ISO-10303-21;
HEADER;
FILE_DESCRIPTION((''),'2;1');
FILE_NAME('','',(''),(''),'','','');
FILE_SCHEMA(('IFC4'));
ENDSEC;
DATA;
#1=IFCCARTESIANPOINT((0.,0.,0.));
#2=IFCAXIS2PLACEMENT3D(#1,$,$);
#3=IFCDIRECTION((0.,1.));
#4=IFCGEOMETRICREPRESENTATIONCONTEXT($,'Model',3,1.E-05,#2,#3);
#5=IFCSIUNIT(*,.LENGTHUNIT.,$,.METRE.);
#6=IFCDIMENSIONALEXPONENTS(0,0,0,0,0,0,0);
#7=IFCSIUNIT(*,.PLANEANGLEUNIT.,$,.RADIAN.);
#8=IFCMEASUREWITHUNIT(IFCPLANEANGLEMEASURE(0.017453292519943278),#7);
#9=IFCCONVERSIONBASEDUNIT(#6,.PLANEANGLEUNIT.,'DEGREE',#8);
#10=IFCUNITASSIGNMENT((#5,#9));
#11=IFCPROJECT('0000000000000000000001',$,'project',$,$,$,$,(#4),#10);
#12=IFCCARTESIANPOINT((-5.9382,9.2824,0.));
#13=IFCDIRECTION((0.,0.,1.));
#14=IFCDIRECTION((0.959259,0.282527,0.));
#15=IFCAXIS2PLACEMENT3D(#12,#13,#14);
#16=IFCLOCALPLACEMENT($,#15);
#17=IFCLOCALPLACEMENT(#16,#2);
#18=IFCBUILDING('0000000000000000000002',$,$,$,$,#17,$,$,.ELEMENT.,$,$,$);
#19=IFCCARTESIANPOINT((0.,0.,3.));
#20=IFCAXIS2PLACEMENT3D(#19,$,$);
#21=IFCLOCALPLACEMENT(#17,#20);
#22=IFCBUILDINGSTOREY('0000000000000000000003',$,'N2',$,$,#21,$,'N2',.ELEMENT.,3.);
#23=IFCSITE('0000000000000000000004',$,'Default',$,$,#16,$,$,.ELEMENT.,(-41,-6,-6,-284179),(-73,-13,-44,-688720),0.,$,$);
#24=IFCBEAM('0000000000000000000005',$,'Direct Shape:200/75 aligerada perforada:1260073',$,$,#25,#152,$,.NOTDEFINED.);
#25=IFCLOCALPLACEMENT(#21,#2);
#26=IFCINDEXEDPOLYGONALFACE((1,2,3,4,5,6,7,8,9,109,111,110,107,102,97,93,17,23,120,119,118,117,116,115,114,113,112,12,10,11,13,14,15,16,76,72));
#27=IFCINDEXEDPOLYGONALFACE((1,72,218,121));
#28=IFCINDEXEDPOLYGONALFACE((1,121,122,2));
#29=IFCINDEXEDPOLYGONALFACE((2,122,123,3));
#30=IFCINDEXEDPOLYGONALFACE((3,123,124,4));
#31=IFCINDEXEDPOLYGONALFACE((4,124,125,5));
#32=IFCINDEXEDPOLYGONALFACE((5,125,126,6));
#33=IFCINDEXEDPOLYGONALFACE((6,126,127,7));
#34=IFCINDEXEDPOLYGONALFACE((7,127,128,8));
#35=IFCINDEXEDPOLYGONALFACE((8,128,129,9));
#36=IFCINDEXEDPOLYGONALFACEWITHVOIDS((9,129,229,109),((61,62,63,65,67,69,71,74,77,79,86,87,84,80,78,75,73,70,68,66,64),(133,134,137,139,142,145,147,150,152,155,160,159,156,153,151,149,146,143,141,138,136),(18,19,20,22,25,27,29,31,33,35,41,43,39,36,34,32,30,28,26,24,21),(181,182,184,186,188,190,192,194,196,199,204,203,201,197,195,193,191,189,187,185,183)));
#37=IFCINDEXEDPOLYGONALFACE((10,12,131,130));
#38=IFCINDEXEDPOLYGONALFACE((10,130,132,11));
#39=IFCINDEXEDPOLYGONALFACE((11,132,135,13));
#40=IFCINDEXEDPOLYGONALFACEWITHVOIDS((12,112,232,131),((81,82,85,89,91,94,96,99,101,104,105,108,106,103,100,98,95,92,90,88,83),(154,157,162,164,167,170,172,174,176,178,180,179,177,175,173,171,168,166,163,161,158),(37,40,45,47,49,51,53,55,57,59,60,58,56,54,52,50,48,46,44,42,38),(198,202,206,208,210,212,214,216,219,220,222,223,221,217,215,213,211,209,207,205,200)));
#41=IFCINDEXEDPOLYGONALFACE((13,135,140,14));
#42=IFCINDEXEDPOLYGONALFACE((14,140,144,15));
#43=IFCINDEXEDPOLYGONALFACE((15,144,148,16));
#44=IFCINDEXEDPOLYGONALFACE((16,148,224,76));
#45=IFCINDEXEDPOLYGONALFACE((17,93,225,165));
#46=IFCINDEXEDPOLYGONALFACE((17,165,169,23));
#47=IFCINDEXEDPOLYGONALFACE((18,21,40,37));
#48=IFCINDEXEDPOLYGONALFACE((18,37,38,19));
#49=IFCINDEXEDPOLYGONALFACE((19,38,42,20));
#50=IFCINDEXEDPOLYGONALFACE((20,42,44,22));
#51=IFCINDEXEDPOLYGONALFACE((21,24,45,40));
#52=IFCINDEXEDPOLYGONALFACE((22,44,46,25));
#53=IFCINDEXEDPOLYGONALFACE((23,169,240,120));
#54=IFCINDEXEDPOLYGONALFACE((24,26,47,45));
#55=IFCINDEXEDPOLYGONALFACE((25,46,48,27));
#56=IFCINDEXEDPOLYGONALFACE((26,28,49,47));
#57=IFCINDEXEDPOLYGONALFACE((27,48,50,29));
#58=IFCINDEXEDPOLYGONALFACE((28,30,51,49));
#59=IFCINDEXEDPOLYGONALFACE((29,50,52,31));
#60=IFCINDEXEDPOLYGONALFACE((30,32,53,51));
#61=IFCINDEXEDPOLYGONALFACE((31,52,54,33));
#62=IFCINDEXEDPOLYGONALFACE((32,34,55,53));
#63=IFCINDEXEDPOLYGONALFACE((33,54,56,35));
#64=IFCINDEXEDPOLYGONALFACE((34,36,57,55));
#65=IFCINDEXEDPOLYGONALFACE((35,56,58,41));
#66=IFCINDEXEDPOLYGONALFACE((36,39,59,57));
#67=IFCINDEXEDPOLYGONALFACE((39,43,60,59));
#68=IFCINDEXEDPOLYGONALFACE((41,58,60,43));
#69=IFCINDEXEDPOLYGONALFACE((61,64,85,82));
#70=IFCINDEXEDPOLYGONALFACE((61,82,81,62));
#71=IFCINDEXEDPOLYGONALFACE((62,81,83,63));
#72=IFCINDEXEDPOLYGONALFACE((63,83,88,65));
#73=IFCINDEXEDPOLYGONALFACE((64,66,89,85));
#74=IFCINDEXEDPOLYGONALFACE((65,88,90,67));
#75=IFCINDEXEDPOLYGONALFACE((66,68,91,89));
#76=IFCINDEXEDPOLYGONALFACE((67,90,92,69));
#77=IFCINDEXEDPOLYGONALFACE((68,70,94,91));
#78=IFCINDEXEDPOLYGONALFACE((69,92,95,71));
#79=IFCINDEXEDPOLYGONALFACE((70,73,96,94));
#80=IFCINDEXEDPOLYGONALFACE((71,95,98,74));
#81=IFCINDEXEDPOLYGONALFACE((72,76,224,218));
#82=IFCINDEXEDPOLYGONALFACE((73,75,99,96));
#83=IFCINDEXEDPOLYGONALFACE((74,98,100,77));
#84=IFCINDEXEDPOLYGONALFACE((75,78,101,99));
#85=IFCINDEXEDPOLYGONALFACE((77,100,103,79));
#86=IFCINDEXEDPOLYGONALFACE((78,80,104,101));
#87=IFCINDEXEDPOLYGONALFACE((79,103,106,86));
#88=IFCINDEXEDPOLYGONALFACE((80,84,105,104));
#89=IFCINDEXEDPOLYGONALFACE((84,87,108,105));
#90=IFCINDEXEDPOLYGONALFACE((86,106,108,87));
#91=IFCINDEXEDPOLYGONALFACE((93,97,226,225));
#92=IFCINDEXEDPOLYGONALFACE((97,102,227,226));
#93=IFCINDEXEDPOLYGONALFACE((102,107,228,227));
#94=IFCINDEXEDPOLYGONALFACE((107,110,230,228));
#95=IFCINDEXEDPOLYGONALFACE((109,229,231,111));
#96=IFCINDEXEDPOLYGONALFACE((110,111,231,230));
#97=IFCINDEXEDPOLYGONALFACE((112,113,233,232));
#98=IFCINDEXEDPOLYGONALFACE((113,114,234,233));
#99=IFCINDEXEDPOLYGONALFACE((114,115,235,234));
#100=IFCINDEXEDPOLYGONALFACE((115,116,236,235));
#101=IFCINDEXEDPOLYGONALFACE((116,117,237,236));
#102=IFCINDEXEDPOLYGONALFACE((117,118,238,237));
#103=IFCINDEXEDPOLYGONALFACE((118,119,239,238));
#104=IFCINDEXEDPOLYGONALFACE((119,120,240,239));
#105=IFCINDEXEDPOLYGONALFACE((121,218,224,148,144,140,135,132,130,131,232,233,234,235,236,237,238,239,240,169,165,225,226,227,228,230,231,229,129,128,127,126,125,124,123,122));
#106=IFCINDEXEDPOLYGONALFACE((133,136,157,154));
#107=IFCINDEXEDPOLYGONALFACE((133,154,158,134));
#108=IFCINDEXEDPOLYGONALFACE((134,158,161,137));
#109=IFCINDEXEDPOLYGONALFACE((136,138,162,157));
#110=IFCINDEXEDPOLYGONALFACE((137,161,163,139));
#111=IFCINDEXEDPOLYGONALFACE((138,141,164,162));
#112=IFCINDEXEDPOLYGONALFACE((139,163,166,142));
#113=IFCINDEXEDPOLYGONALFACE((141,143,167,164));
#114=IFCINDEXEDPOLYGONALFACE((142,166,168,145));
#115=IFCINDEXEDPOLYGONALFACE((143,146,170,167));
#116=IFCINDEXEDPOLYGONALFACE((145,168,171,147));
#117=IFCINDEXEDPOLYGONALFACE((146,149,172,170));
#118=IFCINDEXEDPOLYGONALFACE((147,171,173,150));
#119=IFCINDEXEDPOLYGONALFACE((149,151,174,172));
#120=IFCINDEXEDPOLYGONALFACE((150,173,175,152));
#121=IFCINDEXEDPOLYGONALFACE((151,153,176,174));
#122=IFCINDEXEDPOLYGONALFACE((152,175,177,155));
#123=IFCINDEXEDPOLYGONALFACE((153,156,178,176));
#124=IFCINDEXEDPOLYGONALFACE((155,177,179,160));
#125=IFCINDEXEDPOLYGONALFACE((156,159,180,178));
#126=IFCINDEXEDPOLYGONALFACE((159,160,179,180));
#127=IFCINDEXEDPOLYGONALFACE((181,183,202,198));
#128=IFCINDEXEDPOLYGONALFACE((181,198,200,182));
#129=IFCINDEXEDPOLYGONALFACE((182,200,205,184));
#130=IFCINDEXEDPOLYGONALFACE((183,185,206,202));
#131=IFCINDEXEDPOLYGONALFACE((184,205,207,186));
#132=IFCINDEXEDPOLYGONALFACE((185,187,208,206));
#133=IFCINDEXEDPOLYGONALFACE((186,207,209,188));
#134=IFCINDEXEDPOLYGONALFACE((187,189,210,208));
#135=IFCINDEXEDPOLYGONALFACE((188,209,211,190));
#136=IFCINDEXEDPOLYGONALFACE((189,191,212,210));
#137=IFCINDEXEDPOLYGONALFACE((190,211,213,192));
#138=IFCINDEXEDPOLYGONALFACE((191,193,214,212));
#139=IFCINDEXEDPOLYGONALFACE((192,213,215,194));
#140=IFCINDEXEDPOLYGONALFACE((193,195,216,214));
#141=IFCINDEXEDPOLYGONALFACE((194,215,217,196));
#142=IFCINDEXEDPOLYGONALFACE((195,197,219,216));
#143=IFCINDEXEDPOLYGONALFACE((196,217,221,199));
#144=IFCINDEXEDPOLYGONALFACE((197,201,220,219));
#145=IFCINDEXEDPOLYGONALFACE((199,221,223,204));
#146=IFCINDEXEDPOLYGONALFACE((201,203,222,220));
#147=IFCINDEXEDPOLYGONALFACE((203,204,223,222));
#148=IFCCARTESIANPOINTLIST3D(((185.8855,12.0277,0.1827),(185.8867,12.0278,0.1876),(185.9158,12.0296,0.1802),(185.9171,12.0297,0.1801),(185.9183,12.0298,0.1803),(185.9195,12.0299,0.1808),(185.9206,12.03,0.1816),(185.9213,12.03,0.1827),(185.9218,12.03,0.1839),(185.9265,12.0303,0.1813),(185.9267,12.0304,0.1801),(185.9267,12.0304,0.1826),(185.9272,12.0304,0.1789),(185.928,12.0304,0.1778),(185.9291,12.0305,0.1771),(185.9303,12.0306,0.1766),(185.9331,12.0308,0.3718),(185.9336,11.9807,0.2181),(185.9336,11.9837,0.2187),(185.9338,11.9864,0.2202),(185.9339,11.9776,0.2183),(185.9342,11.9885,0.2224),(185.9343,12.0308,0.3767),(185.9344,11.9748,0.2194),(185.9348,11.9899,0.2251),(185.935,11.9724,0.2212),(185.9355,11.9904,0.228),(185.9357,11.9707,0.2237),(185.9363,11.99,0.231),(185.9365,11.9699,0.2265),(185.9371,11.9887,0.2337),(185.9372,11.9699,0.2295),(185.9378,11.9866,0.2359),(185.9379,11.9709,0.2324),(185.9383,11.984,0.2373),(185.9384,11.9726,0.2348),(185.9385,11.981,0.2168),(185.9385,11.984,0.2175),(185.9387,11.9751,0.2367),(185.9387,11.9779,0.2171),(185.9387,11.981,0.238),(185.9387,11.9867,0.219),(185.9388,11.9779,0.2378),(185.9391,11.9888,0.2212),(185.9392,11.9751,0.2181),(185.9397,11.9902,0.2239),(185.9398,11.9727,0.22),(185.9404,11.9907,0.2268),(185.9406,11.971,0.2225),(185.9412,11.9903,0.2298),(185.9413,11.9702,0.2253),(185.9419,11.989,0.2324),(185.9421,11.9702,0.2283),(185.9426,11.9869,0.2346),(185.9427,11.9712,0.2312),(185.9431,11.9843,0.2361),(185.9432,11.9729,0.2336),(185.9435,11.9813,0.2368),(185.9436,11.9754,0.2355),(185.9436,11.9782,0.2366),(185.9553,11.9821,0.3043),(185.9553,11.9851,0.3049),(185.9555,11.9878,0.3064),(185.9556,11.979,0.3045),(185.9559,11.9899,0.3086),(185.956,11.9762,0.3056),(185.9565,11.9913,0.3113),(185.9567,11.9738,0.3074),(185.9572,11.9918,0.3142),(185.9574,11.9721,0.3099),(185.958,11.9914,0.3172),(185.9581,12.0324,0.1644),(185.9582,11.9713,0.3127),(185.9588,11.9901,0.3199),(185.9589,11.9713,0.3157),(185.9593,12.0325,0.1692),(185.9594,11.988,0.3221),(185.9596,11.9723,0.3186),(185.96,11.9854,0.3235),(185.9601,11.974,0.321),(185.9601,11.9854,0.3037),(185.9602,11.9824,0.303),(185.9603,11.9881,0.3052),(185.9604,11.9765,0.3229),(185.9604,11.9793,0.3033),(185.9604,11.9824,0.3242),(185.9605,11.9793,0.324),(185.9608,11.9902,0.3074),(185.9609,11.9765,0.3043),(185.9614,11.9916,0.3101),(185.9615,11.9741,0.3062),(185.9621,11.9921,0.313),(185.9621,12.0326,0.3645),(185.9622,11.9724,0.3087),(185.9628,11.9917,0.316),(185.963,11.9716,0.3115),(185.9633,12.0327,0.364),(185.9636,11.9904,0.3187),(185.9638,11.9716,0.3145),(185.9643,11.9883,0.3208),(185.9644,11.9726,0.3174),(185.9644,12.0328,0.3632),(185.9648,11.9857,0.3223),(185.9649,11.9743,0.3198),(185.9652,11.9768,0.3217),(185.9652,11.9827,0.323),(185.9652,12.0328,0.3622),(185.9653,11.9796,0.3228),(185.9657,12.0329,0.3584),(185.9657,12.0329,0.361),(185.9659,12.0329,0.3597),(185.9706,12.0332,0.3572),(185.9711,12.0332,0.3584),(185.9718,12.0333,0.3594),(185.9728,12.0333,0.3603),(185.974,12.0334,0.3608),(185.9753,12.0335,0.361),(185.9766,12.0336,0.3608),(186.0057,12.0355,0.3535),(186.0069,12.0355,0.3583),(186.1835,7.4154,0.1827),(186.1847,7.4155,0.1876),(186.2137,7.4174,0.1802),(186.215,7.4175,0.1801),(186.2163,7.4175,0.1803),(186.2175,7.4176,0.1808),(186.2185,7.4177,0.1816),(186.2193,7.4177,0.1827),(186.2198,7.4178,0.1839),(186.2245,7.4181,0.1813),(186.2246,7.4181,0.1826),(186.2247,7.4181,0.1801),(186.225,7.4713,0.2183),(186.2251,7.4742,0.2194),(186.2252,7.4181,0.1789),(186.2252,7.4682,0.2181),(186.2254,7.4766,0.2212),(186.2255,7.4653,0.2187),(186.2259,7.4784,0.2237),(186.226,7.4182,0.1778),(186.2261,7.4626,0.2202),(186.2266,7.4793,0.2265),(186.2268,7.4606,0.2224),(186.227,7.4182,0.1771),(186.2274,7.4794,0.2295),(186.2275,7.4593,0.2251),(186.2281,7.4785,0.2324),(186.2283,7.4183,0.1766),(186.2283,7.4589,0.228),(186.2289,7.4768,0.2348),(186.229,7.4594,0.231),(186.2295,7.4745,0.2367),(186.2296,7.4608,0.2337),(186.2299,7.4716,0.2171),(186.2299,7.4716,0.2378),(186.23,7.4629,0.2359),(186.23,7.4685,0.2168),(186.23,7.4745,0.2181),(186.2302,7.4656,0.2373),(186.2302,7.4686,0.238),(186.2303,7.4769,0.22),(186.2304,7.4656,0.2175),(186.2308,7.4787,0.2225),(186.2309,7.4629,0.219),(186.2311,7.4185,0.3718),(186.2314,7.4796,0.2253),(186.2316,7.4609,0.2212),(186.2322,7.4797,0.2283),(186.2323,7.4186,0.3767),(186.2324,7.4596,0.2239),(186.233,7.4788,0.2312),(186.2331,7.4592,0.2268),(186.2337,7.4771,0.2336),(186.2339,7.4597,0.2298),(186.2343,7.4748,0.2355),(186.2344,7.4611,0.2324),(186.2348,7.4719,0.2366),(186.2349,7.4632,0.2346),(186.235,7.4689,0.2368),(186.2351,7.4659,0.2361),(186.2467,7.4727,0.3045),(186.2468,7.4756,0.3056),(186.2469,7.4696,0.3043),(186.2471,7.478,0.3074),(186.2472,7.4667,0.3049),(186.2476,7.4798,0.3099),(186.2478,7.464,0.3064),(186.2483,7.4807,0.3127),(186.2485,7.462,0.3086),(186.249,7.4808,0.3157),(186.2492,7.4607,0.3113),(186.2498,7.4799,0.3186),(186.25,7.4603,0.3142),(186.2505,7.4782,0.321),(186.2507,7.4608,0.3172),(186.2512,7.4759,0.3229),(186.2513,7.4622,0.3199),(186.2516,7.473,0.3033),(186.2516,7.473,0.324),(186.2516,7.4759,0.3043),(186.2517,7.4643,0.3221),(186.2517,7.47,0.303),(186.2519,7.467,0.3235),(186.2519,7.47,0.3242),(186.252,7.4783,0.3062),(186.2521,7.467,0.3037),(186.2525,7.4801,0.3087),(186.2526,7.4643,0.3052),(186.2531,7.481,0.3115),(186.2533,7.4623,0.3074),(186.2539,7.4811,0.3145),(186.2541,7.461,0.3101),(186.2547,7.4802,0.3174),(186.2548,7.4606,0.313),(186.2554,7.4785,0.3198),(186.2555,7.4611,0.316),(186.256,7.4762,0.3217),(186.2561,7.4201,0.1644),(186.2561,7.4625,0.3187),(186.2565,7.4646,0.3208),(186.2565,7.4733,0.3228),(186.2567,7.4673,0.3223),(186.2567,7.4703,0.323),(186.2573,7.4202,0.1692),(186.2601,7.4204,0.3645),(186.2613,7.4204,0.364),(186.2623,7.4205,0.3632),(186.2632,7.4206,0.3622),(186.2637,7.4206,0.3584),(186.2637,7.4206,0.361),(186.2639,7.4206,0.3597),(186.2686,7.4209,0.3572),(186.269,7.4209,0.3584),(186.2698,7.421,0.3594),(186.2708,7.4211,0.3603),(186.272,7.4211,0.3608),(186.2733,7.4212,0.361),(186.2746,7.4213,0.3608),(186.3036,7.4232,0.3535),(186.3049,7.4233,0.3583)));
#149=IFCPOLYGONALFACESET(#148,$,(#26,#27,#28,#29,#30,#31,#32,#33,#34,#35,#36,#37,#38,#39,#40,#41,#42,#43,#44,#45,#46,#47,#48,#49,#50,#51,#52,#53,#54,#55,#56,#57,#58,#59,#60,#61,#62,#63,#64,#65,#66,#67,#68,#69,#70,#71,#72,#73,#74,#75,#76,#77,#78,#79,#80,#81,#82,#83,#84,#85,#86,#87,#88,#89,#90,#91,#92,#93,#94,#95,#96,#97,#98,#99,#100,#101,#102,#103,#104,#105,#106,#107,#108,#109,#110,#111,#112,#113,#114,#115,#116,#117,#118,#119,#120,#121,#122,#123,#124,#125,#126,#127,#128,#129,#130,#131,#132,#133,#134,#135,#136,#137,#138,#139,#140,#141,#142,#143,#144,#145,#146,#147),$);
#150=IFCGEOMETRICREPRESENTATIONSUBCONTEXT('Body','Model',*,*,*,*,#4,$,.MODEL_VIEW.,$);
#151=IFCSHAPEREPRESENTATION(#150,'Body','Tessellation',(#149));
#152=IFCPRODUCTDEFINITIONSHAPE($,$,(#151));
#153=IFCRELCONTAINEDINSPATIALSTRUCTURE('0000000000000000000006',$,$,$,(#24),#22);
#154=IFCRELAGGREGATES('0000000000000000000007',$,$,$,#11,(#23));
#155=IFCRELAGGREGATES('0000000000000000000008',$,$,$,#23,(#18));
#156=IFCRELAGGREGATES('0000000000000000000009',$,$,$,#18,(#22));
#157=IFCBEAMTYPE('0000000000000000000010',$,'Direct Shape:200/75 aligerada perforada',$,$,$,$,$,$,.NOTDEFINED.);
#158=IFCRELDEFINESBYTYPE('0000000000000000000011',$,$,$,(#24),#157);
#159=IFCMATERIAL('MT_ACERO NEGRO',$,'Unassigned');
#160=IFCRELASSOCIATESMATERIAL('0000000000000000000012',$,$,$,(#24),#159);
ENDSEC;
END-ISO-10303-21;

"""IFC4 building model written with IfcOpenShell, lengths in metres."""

from ifc_helpers import new_model, entity, si_unit, converted_unit, direction, frame, frame_2d, origin, place, context, subcontext, project, spatial, circle, i_section, extrude, material, type_object, element, save


model = new_model("IFC4")

# Units and contexts
model_context = context("Model", 3, precision=1e-05, world=origin(), true_north=direction((0.0, 1.0)))
body_context = subcontext(model_context, "Body", "Model", "MODEL_VIEW")
ifc_project = project(units=[si_unit("LENGTHUNIT", "METRE"), converted_unit("PLANEANGLEUNIT", "DEGREE", entity("IfcPlaneAngleMeasure", 0.017453292519943278), si_unit("PLANEANGLEUNIT", "RADIAN"), dimensions=[0, 0, 0, 0, 0, 0, 0])], contexts=[model_context])

# Site, building, storey
site_placement = place(None, frame((-5.9382, 9.2824, 0.0), z_axis=(0.0, 0.0, 1.0), x_axis=(0.959259, 0.282527, 0.0)))
site = spatial("IfcSite", under=ifc_project, at=site_placement, Name="Default", CompositionType="ELEMENT", RefLatitude=(-41, -6, -6, -284179), RefLongitude=(-73, -13, -44, -688720), RefElevation=0.0)
building_placement = place(site_placement, origin())
building = spatial("IfcBuilding", under=site, at=building_placement, CompositionType="ELEMENT")
storey_placement = place(building_placement, frame((0.0, 0.0, 3.0)))
storey = spatial("IfcBuildingStorey", under=building, at=storey_placement, Name="N2", LongName="N2", CompositionType="ELEMENT", Elevation=3.0)

# Beam, openings
ifc_material = material(Name="MT_ACERO NEGRO", Category="Unassigned")
beam_type_1 = type_object("IfcBeamType", Name="Direct Shape:200/75 aligerada perforada", PredefinedType="NOTDEFINED")
beam_1_placement = place(storey_placement, origin())
beam_1 = element("IfcBeam", 1, at=beam_1_placement, inside=storey, type_object=beam_type_1, material=ifc_material, Name="Direct Shape:200/75 aligerada perforada:1260073", PredefinedType="NOTDEFINED", context=body_context, shape_type="SweptSolid", body=[
    extrude(i_section(OverallWidth=0.075, OverallDepth=0.2, WebThickness=0.005, FlangeThickness=0.005, FilletRadius=0.005, at=frame_2d((0.0, 0.0), x_axis=(0.0, 1.0))), frame((186.2442, 7.4193, 0.2705), z_axis=(-0.064471, 0.99792, 0.0), x_axis=(0.243953, 0.015761, 0.969659)), (0.0, 0.0, 1.0), 4.6219),
])
opening_1_placement = place(storey_placement, origin())
element("IfcOpeningElement", 2, at=opening_1_placement, cuts=beam_1, PredefinedType="OPENING", context=body_context, shape_type="SweptSolid", body=[
    extrude(circle(Radius=0.0103, at=frame_2d((0.0, 0.0), x_axis=(1.0, 0.0))), frame((185.9362, 11.9801, 0.228), z_axis=(0.967642, 0.062515, -0.244461), x_axis=(-0.064446, 0.997921, 0.0001)), (0.0, 0.0, 1.0), 0.005),
])
opening_2_placement = place(storey_placement, origin())
element("IfcOpeningElement", 3, at=opening_2_placement, cuts=beam_1, PredefinedType="OPENING", context=body_context, shape_type="SweptSolid", body=[
    extrude(circle(Radius=0.0103, at=frame_2d((0.0, 0.0), x_axis=(1.0, 0.0))), frame((185.9579, 11.9815, 0.3142), z_axis=(0.967642, 0.062515, -0.244461), x_axis=(-0.064446, 0.997921, 0.0001)), (0.0, 0.0, 1.0), 0.005),
])
opening_3_placement = place(storey_placement, origin())
element("IfcOpeningElement", 4, at=opening_3_placement, cuts=beam_1, PredefinedType="OPENING", context=body_context, shape_type="SweptSolid", body=[
    extrude(circle(Radius=0.0103, at=frame_2d((0.0, 0.0), x_axis=(1.0, 0.0))), frame((186.2493, 7.4706, 0.3142), z_axis=(0.967642, 0.062515, -0.244461), x_axis=(0.064497, -0.997918, 0.0001)), (0.0, 0.0, 1.0), 0.005),
])
opening_4_placement = place(storey_placement, origin())
element("IfcOpeningElement", 5, at=opening_4_placement, cuts=beam_1, PredefinedType="OPENING", context=body_context, shape_type="SweptSolid", body=[
    extrude(circle(Radius=0.0103, at=frame_2d((0.0, 0.0), x_axis=(1.0, 0.0))), frame((186.2276, 7.4692, 0.228), z_axis=(0.967642, 0.062515, -0.244461), x_axis=(0.064496, -0.997918, 0.0001)), (0.0, 0.0, 1.0), 0.005),
])

save(model, "model.ifc")
